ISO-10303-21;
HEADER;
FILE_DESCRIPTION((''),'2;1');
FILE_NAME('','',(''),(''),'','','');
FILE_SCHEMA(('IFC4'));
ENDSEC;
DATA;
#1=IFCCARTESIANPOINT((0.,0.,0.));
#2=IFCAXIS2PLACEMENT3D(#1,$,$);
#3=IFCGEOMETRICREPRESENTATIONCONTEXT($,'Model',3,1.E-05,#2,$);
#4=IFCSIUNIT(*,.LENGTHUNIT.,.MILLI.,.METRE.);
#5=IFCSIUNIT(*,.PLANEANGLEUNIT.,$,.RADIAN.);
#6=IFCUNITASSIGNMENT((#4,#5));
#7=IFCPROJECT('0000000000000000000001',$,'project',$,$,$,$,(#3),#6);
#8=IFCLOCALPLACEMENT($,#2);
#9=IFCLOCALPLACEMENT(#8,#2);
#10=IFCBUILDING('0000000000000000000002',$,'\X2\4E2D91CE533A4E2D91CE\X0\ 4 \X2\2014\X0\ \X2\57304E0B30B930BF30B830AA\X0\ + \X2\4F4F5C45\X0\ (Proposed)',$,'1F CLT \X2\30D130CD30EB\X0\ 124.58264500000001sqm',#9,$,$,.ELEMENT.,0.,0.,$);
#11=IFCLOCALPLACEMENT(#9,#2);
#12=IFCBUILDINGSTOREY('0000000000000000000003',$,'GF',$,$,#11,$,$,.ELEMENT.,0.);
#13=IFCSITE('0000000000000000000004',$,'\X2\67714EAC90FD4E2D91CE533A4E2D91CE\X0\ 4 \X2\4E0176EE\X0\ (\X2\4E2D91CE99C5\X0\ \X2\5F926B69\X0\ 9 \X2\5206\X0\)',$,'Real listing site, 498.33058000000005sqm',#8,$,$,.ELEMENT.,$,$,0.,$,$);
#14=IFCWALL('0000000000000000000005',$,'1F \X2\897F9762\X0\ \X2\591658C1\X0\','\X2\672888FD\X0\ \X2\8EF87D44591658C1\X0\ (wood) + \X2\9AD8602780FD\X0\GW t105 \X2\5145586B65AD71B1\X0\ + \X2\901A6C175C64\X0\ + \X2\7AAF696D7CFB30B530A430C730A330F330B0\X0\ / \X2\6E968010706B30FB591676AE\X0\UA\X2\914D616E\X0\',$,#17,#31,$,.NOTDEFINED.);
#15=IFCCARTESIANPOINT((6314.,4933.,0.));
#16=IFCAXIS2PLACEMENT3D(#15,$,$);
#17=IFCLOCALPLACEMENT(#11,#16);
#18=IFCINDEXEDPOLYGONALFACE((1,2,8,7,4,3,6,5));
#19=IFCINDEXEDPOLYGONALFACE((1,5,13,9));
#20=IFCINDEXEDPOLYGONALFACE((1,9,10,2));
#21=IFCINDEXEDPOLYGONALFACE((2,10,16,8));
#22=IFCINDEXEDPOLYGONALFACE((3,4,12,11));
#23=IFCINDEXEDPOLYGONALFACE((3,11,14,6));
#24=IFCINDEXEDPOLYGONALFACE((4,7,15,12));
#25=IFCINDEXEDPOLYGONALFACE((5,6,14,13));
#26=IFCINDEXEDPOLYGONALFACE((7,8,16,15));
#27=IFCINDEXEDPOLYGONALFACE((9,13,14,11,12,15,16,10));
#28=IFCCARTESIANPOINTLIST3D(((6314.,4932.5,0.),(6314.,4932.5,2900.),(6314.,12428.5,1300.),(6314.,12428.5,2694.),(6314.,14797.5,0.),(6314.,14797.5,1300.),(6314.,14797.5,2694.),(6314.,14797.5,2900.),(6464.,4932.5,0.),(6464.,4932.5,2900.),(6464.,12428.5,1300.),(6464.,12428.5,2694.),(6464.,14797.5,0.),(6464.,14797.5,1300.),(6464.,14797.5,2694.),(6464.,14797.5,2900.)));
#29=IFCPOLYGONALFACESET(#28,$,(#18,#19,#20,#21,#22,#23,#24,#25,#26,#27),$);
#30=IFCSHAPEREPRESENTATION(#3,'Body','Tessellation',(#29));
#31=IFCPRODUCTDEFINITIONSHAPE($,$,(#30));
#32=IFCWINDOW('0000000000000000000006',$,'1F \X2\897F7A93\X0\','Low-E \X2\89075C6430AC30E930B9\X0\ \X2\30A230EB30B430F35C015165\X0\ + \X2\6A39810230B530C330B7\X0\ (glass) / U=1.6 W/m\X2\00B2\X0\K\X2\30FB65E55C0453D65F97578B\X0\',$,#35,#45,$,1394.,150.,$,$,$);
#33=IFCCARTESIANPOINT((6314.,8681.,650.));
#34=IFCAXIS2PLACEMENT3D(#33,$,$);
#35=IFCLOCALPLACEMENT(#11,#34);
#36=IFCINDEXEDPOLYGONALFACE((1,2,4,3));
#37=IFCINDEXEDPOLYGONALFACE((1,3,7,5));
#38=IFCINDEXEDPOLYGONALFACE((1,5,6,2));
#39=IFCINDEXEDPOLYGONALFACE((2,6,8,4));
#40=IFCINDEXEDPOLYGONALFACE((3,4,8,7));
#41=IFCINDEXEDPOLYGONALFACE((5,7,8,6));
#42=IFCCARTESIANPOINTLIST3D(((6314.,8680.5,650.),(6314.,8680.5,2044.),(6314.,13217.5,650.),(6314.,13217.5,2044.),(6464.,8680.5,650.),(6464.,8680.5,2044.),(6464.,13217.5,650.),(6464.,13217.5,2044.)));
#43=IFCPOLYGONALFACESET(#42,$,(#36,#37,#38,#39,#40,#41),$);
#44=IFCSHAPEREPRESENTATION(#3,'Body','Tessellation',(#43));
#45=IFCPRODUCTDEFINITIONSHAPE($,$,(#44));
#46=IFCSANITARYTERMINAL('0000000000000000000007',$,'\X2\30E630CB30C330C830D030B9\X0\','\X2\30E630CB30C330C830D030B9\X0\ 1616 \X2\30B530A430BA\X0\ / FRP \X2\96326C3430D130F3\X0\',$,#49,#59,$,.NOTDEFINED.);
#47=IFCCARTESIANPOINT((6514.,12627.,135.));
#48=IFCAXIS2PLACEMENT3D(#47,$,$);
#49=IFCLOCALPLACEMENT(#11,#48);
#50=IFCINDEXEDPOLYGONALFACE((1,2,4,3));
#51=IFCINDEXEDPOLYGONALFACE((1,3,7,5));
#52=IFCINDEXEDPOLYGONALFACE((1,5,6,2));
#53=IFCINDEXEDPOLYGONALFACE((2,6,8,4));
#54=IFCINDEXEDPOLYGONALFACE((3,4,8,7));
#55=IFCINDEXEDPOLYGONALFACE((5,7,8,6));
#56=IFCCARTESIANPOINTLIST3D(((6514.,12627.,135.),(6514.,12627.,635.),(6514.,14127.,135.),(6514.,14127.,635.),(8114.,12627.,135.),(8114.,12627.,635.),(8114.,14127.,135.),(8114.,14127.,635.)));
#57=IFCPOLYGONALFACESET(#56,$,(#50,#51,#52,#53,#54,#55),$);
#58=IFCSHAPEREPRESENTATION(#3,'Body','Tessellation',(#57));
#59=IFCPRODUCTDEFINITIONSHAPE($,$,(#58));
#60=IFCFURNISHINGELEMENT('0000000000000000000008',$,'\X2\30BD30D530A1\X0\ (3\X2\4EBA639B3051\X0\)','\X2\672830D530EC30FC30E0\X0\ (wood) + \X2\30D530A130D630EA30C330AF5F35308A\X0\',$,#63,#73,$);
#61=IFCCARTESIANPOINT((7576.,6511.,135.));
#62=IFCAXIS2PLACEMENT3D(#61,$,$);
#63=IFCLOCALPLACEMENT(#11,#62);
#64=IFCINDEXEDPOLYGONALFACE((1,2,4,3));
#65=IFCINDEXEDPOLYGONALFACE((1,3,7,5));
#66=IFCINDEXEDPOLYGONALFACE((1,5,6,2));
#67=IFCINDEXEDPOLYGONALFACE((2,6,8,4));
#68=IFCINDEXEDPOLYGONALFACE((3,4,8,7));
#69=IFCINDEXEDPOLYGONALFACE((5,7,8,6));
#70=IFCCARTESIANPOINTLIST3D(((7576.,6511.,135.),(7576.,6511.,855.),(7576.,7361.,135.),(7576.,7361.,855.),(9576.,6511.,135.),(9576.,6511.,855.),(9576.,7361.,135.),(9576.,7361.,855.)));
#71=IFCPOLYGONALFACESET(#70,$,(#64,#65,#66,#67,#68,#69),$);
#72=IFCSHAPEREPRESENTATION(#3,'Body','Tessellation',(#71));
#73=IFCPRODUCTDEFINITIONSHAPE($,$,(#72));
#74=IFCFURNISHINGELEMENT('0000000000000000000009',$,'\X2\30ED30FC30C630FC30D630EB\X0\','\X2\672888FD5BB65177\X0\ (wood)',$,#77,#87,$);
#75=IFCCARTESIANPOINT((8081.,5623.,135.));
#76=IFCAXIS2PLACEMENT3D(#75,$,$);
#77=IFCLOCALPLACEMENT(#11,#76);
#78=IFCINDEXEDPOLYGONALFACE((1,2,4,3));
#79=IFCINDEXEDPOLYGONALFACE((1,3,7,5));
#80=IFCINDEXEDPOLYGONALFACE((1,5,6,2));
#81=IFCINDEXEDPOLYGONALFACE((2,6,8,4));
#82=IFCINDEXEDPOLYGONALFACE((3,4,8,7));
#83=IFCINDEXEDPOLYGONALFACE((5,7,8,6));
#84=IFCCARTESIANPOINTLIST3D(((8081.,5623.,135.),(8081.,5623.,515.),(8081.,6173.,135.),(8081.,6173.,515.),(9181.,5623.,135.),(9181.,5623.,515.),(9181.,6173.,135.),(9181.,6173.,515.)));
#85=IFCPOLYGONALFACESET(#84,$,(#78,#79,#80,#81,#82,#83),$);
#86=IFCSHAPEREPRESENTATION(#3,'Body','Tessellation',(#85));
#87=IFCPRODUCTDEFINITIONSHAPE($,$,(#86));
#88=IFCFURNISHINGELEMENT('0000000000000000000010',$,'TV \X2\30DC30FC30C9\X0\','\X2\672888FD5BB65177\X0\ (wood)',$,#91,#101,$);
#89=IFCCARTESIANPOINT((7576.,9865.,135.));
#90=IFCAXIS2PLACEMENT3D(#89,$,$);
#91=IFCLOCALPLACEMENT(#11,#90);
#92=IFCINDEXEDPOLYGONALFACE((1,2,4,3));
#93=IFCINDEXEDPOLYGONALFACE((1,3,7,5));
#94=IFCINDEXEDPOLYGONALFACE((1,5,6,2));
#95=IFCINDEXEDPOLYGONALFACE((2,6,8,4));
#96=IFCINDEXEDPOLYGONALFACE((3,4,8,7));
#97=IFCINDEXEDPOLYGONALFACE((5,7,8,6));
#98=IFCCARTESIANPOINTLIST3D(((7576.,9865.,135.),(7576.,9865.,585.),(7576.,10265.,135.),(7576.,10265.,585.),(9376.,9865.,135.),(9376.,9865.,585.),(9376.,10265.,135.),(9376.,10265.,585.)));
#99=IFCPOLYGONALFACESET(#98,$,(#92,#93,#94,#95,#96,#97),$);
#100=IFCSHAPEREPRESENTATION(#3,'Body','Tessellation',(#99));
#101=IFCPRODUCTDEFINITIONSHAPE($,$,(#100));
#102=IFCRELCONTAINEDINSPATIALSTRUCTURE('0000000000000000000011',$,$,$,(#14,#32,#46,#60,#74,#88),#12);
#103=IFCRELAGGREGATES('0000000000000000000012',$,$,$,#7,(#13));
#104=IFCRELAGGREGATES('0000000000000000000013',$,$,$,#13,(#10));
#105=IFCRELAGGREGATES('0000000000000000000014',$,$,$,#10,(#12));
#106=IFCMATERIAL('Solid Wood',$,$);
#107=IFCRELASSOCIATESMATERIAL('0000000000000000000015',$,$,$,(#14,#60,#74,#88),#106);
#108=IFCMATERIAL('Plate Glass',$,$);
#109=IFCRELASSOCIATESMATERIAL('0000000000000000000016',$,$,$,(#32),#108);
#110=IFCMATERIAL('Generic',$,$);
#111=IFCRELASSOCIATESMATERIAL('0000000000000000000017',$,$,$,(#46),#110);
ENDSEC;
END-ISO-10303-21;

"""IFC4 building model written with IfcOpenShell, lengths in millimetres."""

from ifc_helpers import new_model, si_unit, frame, frame_2d, origin, place, context, project, spatial, rectangle, extrude, material, element, fill, save


model = new_model("IFC4")

# Units and contexts
model_context = context("Model", 3, precision=1e-05, world=origin())
ifc_project = project(units=[si_unit("LENGTHUNIT", "METRE", prefix="MILLI"), si_unit("PLANEANGLEUNIT", "RADIAN")], contexts=[model_context])

# Site, building, storey
site_placement = place(None, origin())
site = spatial("IfcSite", under=ifc_project, at=site_placement, Name="東京都中野区中野 4 丁目 (中野駅 徒歩 9 分)", ObjectType="Real listing site, 498.33058000000005sqm", CompositionType="ELEMENT", RefElevation=0.0)
building_placement = place(site_placement, origin())
building = spatial("IfcBuilding", under=site, at=building_placement, Name="中野区中野 4 — 地下スタジオ + 住居 (Proposed)", ObjectType="1F CLT パネル 124.58264500000001sqm", CompositionType="ELEMENT", ElevationOfRefHeight=0.0, ElevationOfTerrain=0.0)
storey_placement = place(building_placement, origin())
storey = spatial("IfcBuildingStorey", under=building, at=storey_placement, Name="GF", CompositionType="ELEMENT", Elevation=0.0)

# Shared definitions
ifc_material_1 = material(Name="Solid Wood")

# Shared definitions
ifc_material_2 = material(Name="Plate Glass")

# Wall, opening, window
wall_1_placement = place(storey_placement, frame((6314.0, 4933.0, 0.0)))
wall_1 = element("IfcWall", 1, at=wall_1_placement, inside=storey, material=ifc_material_1, Name="1F 西面 外壁", Description="木製 軸組外壁 (wood) + 高性能GW t105 充填断熱 + 通気層 + 窯業系サイディング / 準耐火・外皮UA配慮", PredefinedType="NOTDEFINED", context=model_context, shape_type="SweptSolid", body=[
    extrude(rectangle(XDim=150.0, YDim=9865.0, at=frame_2d((75.0, 4932.0))), frame((6314.0, 4933.0, 0.0)), (0.0, 0.0, 1.0), 2900.0),
])
opening_1_placement = place(storey_placement, frame((6314.0, 8681.0, 650.0)))
opening_1 = element("IfcOpeningElement", 2, at=opening_1_placement, cuts=wall_1, PredefinedType="NOTDEFINED", context=model_context, shape_type="SweptSolid", body=[
    extrude(rectangle(XDim=150.0, YDim=4537.0, at=frame_2d((75.0, 2268.0))), frame((6314.0, 8681.0, 650.0)), (0.0, 0.0, 1.0), 1394.0),
])
window_1_placement = place(storey_placement, frame((6314.0, 8681.0, 650.0)))
window_1 = element("IfcWindow", 3, at=window_1_placement, inside=storey, material=ifc_material_2, Name="1F 西窓", Description="Low-E 複層ガラス アルゴン封入 + 樹脂サッシ (glass) / U=1.6 W/m²K・日射取得型", OverallHeight=1394.0, OverallWidth=150.0, context=model_context, shape_type="SweptSolid", body=[
    extrude(rectangle(XDim=150.0, YDim=4537.0, at=frame_2d((75.0, 2268.0))), frame((6314.0, 8681.0, 650.0)), (0.0, 0.0, 1.0), 1394.0),
])
fill(opening_1, window_1)

# Shared definitions
ifc_material_3 = material(Name="Generic")

# Sanitary terminal
sanitary_terminal_placement = place(storey_placement, frame((6514.0, 12627.0, 135.0)))
element("IfcSanitaryTerminal", 4, at=sanitary_terminal_placement, inside=storey, material=ifc_material_3, Name="ユニットバス", Description="ユニットバス 1616 サイズ / FRP 防水パン", PredefinedType="NOTDEFINED", context=model_context, shape_type="SweptSolid", body=[
    extrude(rectangle(XDim=1600.0, YDim=1500.0, at=frame_2d((800.0, 750.0))), frame((6514.0, 12627.0, 135.0)), (0.0, 0.0, 1.0), 500.0),
])

# Furnishing elements
furnishing_1_placement = place(storey_placement, frame((7576.0, 6511.0, 135.0)))
element("IfcFurnishingElement", 5, at=furnishing_1_placement, inside=storey, material=ifc_material_1, Name="ソファ (3人掛け)", Description="木フレーム (wood) + ファブリック張り", context=model_context, shape_type="SweptSolid", body=[
    extrude(rectangle(XDim=2000.0, YDim=850.0, at=frame_2d((1000.0, 425.0))), frame((7576.0, 6511.0, 135.0)), (0.0, 0.0, 1.0), 720.0),
])
furnishing_2_placement = place(storey_placement, frame((8081.0, 5623.0, 135.0)))
element("IfcFurnishingElement", 6, at=furnishing_2_placement, inside=storey, material=ifc_material_1, Name="ローテーブル", Description="木製家具 (wood)", context=model_context, shape_type="SweptSolid", body=[
    extrude(rectangle(XDim=1100.0, YDim=550.0, at=frame_2d((550.0, 275.0))), frame((8081.0, 5623.0, 135.0)), (0.0, 0.0, 1.0), 380.0),
])
furnishing_3_placement = place(storey_placement, frame((7576.0, 9865.0, 135.0)))
element("IfcFurnishingElement", 7, at=furnishing_3_placement, inside=storey, material=ifc_material_1, Name="TV ボード", Description="木製家具 (wood)", context=model_context, shape_type="SweptSolid", body=[
    extrude(rectangle(XDim=1800.0, YDim=400.0, at=frame_2d((900.0, 200.0))), frame((7576.0, 9865.0, 135.0)), (0.0, 0.0, 1.0), 450.0),
])

save(model, "model.ifc")
